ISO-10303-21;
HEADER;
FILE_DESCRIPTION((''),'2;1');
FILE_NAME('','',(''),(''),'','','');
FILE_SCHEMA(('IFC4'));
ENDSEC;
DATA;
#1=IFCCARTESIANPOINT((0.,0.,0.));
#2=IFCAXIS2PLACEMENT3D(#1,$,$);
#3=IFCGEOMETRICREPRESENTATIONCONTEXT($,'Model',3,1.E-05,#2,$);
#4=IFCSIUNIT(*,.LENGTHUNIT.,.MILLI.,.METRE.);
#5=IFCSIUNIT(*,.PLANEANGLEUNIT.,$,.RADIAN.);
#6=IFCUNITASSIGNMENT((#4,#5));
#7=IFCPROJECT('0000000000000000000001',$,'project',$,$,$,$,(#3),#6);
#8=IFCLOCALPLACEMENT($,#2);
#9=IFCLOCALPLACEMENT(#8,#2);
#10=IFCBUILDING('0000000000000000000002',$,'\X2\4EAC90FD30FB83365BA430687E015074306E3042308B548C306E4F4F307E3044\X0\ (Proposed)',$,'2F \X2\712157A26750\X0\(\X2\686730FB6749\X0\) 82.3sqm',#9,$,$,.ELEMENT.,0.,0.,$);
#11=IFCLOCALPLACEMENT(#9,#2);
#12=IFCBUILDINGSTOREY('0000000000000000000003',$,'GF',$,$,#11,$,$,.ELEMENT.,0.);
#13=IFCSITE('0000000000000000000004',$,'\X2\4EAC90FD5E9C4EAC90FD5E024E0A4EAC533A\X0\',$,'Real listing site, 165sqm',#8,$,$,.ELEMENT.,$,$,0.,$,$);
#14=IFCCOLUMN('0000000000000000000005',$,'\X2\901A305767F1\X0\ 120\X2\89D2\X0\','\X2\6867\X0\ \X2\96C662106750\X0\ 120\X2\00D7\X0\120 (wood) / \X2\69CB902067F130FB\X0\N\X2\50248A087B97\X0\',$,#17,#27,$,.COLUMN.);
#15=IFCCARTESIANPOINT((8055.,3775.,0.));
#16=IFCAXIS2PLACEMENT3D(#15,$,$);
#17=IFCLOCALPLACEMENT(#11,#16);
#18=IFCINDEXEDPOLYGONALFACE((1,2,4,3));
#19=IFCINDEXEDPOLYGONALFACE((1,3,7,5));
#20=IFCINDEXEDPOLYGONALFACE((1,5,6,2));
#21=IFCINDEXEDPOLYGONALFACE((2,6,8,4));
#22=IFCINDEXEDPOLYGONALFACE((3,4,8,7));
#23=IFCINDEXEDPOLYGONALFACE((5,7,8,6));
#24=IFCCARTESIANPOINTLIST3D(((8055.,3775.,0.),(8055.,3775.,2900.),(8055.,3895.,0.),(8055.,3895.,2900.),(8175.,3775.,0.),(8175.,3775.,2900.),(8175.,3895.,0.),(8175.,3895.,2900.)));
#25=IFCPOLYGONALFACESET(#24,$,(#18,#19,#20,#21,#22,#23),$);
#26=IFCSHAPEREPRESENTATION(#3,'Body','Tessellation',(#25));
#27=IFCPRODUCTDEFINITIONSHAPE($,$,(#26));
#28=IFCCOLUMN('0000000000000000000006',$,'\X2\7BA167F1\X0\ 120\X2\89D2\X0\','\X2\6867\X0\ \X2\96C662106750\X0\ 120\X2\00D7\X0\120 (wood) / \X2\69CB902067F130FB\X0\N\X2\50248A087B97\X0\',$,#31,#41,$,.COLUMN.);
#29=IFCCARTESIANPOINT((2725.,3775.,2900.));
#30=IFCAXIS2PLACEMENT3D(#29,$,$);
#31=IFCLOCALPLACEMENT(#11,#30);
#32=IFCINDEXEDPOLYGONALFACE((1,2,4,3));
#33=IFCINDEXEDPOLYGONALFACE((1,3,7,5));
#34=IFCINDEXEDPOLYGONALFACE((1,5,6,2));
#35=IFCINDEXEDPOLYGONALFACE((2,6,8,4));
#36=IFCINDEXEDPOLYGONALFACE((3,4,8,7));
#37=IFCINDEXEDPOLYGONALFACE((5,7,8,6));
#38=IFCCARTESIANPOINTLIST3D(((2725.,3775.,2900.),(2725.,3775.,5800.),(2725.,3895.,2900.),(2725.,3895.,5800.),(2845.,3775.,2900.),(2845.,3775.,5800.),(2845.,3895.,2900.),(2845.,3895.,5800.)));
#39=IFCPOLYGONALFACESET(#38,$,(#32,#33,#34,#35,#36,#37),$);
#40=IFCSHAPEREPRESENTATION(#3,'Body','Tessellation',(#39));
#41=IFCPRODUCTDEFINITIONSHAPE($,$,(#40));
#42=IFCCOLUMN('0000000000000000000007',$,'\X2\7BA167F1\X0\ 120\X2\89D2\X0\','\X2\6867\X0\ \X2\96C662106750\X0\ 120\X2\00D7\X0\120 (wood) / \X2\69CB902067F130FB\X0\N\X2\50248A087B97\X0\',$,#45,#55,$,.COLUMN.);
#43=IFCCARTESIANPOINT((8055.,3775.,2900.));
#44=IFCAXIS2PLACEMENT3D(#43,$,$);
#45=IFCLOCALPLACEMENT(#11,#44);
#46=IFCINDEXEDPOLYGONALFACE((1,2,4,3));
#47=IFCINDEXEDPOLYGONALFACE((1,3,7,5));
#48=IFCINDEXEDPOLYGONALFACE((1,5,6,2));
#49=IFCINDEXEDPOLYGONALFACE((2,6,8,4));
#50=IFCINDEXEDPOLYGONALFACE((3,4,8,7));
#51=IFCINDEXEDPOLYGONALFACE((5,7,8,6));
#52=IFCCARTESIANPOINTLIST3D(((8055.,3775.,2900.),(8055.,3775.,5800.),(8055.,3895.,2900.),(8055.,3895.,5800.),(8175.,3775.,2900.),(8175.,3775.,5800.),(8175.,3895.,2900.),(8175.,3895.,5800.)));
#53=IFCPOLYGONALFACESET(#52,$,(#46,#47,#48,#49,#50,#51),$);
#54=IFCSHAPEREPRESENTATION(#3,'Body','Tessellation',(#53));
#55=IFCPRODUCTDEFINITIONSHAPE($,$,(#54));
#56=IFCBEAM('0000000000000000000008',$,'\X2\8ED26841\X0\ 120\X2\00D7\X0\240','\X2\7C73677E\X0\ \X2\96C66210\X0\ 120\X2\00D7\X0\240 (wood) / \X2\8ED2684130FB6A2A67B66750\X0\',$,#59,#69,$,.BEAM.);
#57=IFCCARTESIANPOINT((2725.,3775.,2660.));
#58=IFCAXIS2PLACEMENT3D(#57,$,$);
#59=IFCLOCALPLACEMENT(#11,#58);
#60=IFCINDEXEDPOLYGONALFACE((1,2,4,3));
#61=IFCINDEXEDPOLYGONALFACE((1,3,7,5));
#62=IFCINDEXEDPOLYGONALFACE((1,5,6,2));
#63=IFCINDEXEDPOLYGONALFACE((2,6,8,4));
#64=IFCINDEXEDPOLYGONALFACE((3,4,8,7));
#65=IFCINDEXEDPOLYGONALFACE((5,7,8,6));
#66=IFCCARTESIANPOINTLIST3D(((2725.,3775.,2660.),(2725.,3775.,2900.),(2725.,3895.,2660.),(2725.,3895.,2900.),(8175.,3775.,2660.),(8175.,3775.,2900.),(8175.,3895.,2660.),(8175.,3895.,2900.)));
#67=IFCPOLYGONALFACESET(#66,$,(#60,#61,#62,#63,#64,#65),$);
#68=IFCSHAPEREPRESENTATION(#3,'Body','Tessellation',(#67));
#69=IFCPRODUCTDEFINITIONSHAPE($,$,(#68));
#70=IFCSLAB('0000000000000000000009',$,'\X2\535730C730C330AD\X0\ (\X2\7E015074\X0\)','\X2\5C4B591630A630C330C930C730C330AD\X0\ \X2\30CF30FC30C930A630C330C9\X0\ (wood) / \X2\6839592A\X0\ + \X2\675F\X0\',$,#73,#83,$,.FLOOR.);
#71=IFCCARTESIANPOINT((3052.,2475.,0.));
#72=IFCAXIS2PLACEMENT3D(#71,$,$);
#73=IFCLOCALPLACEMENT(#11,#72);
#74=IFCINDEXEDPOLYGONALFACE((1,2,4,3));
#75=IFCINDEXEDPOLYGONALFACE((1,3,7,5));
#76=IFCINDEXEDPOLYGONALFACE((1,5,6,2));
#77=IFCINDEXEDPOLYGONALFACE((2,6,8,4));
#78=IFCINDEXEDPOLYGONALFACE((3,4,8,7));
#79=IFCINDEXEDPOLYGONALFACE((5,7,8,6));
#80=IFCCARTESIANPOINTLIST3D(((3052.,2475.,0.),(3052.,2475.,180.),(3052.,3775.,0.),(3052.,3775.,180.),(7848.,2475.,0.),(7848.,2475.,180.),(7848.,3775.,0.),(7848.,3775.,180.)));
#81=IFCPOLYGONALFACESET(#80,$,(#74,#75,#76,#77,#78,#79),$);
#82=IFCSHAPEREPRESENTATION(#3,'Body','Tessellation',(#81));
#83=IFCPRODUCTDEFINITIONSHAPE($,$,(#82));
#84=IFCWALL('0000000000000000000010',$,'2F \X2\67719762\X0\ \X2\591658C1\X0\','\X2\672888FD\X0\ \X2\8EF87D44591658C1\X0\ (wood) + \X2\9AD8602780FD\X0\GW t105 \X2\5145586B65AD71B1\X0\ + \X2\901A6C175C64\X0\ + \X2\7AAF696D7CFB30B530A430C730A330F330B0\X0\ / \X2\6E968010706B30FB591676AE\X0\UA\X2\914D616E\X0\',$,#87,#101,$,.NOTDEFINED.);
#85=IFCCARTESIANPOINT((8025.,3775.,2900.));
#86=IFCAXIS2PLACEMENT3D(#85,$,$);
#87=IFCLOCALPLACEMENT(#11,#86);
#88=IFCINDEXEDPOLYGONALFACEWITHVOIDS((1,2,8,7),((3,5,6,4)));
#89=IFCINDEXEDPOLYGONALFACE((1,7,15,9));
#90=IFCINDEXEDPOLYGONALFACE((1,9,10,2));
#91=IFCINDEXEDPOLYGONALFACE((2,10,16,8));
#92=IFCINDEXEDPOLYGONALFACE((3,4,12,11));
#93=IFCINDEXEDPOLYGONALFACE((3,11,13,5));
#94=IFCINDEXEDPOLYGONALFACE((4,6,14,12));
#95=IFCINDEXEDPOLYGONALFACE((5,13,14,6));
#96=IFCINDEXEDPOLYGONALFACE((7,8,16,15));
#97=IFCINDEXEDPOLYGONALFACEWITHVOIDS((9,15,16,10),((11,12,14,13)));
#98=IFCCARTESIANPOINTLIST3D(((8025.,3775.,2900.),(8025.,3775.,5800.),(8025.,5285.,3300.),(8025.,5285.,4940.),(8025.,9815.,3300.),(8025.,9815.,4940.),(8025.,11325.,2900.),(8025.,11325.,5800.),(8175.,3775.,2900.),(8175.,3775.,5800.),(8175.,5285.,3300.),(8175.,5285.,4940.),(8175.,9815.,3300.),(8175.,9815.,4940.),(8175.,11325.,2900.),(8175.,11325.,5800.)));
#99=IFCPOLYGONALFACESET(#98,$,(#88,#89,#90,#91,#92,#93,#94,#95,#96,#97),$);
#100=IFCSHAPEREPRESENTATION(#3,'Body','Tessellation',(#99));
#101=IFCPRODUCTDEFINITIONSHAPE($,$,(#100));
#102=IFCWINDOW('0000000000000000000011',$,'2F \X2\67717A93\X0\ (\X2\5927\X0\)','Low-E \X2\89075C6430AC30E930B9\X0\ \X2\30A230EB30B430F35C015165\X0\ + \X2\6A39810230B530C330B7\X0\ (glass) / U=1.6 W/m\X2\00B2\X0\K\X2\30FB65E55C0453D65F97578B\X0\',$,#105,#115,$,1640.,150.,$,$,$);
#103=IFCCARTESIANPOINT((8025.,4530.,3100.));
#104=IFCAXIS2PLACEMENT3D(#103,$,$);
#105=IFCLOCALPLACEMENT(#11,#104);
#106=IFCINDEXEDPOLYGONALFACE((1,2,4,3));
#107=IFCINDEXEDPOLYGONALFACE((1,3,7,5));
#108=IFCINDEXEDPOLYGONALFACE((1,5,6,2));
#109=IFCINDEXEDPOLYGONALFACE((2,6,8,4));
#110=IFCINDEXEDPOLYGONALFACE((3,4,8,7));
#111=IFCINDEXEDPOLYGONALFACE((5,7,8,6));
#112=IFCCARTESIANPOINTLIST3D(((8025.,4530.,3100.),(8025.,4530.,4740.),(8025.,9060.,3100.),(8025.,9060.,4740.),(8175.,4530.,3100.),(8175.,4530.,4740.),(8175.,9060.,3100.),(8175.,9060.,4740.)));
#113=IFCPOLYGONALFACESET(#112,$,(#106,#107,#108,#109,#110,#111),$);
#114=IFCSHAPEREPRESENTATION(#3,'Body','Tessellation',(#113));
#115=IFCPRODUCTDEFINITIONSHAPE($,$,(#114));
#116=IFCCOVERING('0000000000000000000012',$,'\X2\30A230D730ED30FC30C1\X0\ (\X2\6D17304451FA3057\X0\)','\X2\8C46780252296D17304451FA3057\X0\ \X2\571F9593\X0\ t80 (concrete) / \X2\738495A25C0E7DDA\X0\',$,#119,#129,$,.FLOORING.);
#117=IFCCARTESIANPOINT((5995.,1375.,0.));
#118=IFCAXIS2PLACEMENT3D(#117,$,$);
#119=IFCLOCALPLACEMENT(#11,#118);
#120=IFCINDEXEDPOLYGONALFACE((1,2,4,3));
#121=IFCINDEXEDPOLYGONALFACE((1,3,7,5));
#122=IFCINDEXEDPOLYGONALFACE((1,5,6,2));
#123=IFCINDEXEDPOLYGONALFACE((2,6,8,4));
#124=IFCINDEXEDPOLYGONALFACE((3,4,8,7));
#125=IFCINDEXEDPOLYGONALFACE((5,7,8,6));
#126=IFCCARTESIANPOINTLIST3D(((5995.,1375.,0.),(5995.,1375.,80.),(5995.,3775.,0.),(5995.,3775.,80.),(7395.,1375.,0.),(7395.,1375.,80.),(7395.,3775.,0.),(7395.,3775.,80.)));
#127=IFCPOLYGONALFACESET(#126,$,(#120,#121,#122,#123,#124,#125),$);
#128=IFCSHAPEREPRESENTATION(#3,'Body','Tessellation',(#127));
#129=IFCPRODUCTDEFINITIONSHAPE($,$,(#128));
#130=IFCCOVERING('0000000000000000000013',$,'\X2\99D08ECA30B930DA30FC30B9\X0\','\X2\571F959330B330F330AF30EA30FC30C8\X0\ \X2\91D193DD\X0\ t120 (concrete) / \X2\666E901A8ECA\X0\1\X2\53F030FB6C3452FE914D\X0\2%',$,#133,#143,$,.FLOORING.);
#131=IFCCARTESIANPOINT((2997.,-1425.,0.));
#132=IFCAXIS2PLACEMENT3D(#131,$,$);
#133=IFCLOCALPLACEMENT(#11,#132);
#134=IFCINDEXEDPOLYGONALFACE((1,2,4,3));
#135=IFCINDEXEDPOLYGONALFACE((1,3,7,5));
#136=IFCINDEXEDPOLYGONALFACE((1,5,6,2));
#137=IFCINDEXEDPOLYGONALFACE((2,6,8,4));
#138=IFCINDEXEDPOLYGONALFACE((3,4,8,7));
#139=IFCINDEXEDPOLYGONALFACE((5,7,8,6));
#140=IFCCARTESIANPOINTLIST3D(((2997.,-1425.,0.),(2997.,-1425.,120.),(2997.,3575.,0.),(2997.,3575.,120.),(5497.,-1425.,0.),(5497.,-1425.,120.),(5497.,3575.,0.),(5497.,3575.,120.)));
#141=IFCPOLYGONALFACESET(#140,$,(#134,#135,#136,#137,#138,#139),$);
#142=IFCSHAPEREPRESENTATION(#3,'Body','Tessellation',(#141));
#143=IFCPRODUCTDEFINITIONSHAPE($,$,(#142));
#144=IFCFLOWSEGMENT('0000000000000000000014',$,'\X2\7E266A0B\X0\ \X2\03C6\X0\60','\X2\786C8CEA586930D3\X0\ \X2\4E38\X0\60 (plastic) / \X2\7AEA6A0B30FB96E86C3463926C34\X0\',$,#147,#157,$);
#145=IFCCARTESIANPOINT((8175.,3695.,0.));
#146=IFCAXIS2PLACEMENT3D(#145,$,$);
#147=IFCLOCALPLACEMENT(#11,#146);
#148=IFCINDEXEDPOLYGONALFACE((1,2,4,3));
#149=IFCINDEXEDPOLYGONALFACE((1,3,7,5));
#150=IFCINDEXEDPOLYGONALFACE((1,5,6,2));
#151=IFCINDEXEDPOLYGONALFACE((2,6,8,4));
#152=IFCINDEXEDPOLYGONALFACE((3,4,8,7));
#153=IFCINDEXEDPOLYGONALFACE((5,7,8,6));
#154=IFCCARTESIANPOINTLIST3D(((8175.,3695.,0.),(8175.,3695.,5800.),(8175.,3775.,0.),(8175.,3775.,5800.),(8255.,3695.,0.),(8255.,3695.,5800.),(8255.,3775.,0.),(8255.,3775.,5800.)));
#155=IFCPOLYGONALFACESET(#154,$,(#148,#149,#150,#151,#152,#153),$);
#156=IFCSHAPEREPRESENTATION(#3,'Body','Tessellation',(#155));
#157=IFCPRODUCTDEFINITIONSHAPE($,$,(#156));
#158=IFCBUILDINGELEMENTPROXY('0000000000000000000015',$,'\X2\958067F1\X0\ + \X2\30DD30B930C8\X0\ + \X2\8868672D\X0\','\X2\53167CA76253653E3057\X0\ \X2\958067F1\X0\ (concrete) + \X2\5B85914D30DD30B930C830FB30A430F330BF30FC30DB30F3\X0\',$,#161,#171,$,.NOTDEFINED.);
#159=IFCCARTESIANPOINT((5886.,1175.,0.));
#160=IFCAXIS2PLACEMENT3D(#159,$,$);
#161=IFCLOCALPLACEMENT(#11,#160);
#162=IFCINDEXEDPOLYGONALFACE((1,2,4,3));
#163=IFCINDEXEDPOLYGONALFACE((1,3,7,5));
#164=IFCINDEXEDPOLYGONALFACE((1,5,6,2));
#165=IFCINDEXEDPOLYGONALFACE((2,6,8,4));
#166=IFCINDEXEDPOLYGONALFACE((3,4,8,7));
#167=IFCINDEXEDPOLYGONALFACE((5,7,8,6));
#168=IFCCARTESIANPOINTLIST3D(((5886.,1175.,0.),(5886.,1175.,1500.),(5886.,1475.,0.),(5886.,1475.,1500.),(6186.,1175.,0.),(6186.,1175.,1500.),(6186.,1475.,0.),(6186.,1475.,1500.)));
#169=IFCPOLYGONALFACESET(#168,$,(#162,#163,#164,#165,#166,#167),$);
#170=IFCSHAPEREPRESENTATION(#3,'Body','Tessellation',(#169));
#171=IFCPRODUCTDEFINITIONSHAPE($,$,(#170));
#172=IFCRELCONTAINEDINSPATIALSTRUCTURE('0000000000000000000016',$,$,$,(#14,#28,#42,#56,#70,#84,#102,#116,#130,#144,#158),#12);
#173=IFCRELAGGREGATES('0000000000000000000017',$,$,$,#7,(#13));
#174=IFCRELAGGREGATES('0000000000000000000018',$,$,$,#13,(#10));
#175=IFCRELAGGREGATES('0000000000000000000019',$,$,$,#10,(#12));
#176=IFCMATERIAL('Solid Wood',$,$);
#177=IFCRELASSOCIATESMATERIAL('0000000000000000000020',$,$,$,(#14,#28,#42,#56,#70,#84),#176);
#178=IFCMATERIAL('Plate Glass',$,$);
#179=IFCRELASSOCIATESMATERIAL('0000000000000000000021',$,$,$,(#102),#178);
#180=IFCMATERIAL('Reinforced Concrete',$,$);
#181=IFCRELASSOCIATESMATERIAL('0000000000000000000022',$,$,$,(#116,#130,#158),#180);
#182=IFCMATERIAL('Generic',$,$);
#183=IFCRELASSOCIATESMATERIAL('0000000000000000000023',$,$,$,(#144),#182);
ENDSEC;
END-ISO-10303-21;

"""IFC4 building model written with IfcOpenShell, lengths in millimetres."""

from ifc_helpers import new_model, si_unit, frame, frame_2d, origin, place, context, project, spatial, rectangle, extrude, material, element, fill, save


model = new_model("IFC4")

# Units and contexts
model_context = context("Model", 3, precision=1e-05, world=origin())
ifc_project = project(units=[si_unit("LENGTHUNIT", "METRE", prefix="MILLI"), si_unit("PLANEANGLEUNIT", "RADIAN")], contexts=[model_context])

# Site, building, storey
site_placement = place(None, origin())
site = spatial("IfcSite", under=ifc_project, at=site_placement, Name="京都府京都市上京区", ObjectType="Real listing site, 165sqm", CompositionType="ELEMENT", RefElevation=0.0)
building_placement = place(site_placement, origin())
building = spatial("IfcBuilding", under=site, at=building_placement, Name="京都・茶室と縁側のある和の住まい (Proposed)", ObjectType="2F 無垢材(桧・杉) 82.3sqm", CompositionType="ELEMENT", ElevationOfRefHeight=0.0, ElevationOfTerrain=0.0)
storey_placement = place(building_placement, origin())
storey = spatial("IfcBuildingStorey", under=building, at=storey_placement, Name="GF", CompositionType="ELEMENT", Elevation=0.0)

# Columns
ifc_material_1 = material(Name="Solid Wood")
column_1_placement = place(storey_placement, frame((8055.0, 3775.0, 0.0)))
element("IfcColumn", 1, at=column_1_placement, inside=storey, material=ifc_material_1, Name="通し柱 120角", Description="桧 集成材 120×120 (wood) / 構造柱・N値計算", PredefinedType="COLUMN", context=model_context, shape_type="SweptSolid", body=[
    extrude(rectangle(XDim=120.0, YDim=120.0, at=frame_2d((60.0, 60.0))), frame((8055.0, 3775.0, 0.0)), (0.0, 0.0, 1.0), 2900.0),
])
column_2_placement = place(storey_placement, frame((2725.0, 3775.0, 2900.0)))
element("IfcColumn", 2, at=column_2_placement, inside=storey, material=ifc_material_1, Name="管柱 120角", Description="桧 集成材 120×120 (wood) / 構造柱・N値計算", PredefinedType="COLUMN", context=model_context, shape_type="SweptSolid", body=[
    extrude(rectangle(XDim=120.0, YDim=120.0, at=frame_2d((60.0, 60.0))), frame((2725.0, 3775.0, 2900.0)), (0.0, 0.0, 1.0), 2900.0),
])
column_3_placement = place(storey_placement, frame((8055.0, 3775.0, 2900.0)))
element("IfcColumn", 3, at=column_3_placement, inside=storey, material=ifc_material_1, Name="管柱 120角", Description="桧 集成材 120×120 (wood) / 構造柱・N値計算", PredefinedType="COLUMN", context=model_context, shape_type="SweptSolid", body=[
    extrude(rectangle(XDim=120.0, YDim=120.0, at=frame_2d((60.0, 60.0))), frame((8055.0, 3775.0, 2900.0)), (0.0, 0.0, 1.0), 2900.0),
])

# Beam
beam_1_placement = place(storey_placement, frame((2725.0, 3775.0, 2660.0)))
element("IfcBeam", 4, at=beam_1_placement, inside=storey, material=ifc_material_1, Name="軒桁 120×240", Description="米松 集成 120×240 (wood) / 軒桁・横架材", PredefinedType="BEAM", context=model_context, shape_type="SweptSolid", body=[
    extrude(rectangle(XDim=5450.0, YDim=120.0, at=frame_2d((2725.0, 60.0))), frame((2725.0, 3775.0, 2660.0)), (0.0, 0.0, 1.0), 240.0),
])

# Slab
slab_placement = place(storey_placement, frame((3052.0, 2475.0, 0.0)))
element("IfcSlab", 5, at=slab_placement, inside=storey, material=ifc_material_1, Name="南デッキ (縁側)", Description="屋外ウッドデッキ ハードウッド (wood) / 根太 + 束", PredefinedType="FLOOR", context=model_context, shape_type="SweptSolid", body=[
    extrude(rectangle(XDim=4796.0, YDim=1300.0, at=frame_2d((2398.0, 650.0))), frame((3052.0, 2475.0, 0.0)), (0.0, 0.0, 1.0), 180.0),
])

# Wall, opening, window
ifc_material_2 = material(Name="Plate Glass")
wall_1_placement = place(storey_placement, frame((8025.0, 3775.0, 2900.0)))
wall_1 = element("IfcWall", 6, at=wall_1_placement, inside=storey, material=ifc_material_1, Name="2F 東面 外壁", Description="木製 軸組外壁 (wood) + 高性能GW t105 充填断熱 + 通気層 + 窯業系サイディング / 準耐火・外皮UA配慮", PredefinedType="NOTDEFINED", context=model_context, shape_type="SweptSolid", body=[
    extrude(rectangle(XDim=150.0, YDim=7550.0, at=frame_2d((75.0, 3775.0))), frame((8025.0, 3775.0, 2900.0)), (0.0, 0.0, 1.0), 2900.0),
])
opening_1_placement = place(storey_placement, frame((8025.0, 4530.0, 3100.0)))
opening_1 = element("IfcOpeningElement", 7, at=opening_1_placement, cuts=wall_1, PredefinedType="NOTDEFINED", context=model_context, shape_type="SweptSolid", body=[
    extrude(rectangle(XDim=150.0, YDim=4530.0, at=frame_2d((75.0, 2265.0))), frame((8025.0, 4530.0, 3100.0)), (0.0, 0.0, 1.0), 1640.0),
])
window_1_placement = place(storey_placement, frame((8025.0, 4530.0, 3100.0)))
window_1 = element("IfcWindow", 8, at=window_1_placement, inside=storey, material=ifc_material_2, Name="2F 東窓 (大)", Description="Low-E 複層ガラス アルゴン封入 + 樹脂サッシ (glass) / U=1.6 W/m²K・日射取得型", OverallHeight=1640.0, OverallWidth=150.0, context=model_context, shape_type="SweptSolid", body=[
    extrude(rectangle(XDim=150.0, YDim=4530.0, at=frame_2d((75.0, 2265.0))), frame((8025.0, 4530.0, 3100.0)), (0.0, 0.0, 1.0), 1640.0),
])
fill(opening_1, window_1)

# Coverings
ifc_material_3 = material(Name="Reinforced Concrete")
covering_1_placement = place(storey_placement, frame((5995.0, 1375.0, 0.0)))
element("IfcCovering", 9, at=covering_1_placement, inside=storey, material=ifc_material_3, Name="アプローチ (洗い出し)", Description="豆砂利洗い出し 土間 t80 (concrete) / 玄関導線", PredefinedType="FLOORING", context=model_context, shape_type="SweptSolid", body=[
    extrude(rectangle(XDim=1400.0, YDim=2400.0, at=frame_2d((700.0, 1200.0))), frame((5995.0, 1375.0, 0.0)), (0.0, 0.0, 1.0), 80.0),
])
covering_2_placement = place(storey_placement, frame((2997.0, -1425.0, 0.0)))
element("IfcCovering", 10, at=covering_2_placement, inside=storey, material=ifc_material_3, Name="駐車スペース", Description="土間コンクリート 金鏝 t120 (concrete) / 普通車1台・水勾配2%", PredefinedType="FLOORING", context=model_context, shape_type="SweptSolid", body=[
    extrude(rectangle(XDim=2500.0, YDim=5000.0, at=frame_2d((1250.0, 2500.0))), frame((2997.0, -1425.0, 0.0)), (0.0, 0.0, 1.0), 120.0),
])

# Flow segment
ifc_material_4 = material(Name="Generic")
flow_segment_placement = place(storey_placement, frame((8175.0, 3695.0, 0.0)))
element("IfcFlowSegment", 11, at=flow_segment_placement, inside=storey, material=ifc_material_4, Name="縦樋 φ60", Description="硬質塩ビ 丸60 (plastic) / 竪樋・雨水排水", context=model_context, shape_type="SweptSolid", body=[
    extrude(rectangle(XDim=80.0, YDim=80.0, at=frame_2d((40.0, 40.0))), frame((8175.0, 3695.0, 0.0)), (0.0, 0.0, 1.0), 5800.0),
])

# Building element proxy
proxy_placement = place(storey_placement, frame((5886.0, 1175.0, 0.0)))
element("IfcBuildingElementProxy", 12, at=proxy_placement, inside=storey, material=ifc_material_3, Name="門柱 + ポスト + 表札", Description="化粧打放し 門柱 (concrete) + 宅配ポスト・インターホン", PredefinedType="NOTDEFINED", context=model_context, shape_type="SweptSolid", body=[
    extrude(rectangle(XDim=300.0, YDim=300.0, at=frame_2d((150.0, 150.0))), frame((5886.0, 1175.0, 0.0)), (0.0, 0.0, 1.0), 1500.0),
])

save(model, "model.ifc")
